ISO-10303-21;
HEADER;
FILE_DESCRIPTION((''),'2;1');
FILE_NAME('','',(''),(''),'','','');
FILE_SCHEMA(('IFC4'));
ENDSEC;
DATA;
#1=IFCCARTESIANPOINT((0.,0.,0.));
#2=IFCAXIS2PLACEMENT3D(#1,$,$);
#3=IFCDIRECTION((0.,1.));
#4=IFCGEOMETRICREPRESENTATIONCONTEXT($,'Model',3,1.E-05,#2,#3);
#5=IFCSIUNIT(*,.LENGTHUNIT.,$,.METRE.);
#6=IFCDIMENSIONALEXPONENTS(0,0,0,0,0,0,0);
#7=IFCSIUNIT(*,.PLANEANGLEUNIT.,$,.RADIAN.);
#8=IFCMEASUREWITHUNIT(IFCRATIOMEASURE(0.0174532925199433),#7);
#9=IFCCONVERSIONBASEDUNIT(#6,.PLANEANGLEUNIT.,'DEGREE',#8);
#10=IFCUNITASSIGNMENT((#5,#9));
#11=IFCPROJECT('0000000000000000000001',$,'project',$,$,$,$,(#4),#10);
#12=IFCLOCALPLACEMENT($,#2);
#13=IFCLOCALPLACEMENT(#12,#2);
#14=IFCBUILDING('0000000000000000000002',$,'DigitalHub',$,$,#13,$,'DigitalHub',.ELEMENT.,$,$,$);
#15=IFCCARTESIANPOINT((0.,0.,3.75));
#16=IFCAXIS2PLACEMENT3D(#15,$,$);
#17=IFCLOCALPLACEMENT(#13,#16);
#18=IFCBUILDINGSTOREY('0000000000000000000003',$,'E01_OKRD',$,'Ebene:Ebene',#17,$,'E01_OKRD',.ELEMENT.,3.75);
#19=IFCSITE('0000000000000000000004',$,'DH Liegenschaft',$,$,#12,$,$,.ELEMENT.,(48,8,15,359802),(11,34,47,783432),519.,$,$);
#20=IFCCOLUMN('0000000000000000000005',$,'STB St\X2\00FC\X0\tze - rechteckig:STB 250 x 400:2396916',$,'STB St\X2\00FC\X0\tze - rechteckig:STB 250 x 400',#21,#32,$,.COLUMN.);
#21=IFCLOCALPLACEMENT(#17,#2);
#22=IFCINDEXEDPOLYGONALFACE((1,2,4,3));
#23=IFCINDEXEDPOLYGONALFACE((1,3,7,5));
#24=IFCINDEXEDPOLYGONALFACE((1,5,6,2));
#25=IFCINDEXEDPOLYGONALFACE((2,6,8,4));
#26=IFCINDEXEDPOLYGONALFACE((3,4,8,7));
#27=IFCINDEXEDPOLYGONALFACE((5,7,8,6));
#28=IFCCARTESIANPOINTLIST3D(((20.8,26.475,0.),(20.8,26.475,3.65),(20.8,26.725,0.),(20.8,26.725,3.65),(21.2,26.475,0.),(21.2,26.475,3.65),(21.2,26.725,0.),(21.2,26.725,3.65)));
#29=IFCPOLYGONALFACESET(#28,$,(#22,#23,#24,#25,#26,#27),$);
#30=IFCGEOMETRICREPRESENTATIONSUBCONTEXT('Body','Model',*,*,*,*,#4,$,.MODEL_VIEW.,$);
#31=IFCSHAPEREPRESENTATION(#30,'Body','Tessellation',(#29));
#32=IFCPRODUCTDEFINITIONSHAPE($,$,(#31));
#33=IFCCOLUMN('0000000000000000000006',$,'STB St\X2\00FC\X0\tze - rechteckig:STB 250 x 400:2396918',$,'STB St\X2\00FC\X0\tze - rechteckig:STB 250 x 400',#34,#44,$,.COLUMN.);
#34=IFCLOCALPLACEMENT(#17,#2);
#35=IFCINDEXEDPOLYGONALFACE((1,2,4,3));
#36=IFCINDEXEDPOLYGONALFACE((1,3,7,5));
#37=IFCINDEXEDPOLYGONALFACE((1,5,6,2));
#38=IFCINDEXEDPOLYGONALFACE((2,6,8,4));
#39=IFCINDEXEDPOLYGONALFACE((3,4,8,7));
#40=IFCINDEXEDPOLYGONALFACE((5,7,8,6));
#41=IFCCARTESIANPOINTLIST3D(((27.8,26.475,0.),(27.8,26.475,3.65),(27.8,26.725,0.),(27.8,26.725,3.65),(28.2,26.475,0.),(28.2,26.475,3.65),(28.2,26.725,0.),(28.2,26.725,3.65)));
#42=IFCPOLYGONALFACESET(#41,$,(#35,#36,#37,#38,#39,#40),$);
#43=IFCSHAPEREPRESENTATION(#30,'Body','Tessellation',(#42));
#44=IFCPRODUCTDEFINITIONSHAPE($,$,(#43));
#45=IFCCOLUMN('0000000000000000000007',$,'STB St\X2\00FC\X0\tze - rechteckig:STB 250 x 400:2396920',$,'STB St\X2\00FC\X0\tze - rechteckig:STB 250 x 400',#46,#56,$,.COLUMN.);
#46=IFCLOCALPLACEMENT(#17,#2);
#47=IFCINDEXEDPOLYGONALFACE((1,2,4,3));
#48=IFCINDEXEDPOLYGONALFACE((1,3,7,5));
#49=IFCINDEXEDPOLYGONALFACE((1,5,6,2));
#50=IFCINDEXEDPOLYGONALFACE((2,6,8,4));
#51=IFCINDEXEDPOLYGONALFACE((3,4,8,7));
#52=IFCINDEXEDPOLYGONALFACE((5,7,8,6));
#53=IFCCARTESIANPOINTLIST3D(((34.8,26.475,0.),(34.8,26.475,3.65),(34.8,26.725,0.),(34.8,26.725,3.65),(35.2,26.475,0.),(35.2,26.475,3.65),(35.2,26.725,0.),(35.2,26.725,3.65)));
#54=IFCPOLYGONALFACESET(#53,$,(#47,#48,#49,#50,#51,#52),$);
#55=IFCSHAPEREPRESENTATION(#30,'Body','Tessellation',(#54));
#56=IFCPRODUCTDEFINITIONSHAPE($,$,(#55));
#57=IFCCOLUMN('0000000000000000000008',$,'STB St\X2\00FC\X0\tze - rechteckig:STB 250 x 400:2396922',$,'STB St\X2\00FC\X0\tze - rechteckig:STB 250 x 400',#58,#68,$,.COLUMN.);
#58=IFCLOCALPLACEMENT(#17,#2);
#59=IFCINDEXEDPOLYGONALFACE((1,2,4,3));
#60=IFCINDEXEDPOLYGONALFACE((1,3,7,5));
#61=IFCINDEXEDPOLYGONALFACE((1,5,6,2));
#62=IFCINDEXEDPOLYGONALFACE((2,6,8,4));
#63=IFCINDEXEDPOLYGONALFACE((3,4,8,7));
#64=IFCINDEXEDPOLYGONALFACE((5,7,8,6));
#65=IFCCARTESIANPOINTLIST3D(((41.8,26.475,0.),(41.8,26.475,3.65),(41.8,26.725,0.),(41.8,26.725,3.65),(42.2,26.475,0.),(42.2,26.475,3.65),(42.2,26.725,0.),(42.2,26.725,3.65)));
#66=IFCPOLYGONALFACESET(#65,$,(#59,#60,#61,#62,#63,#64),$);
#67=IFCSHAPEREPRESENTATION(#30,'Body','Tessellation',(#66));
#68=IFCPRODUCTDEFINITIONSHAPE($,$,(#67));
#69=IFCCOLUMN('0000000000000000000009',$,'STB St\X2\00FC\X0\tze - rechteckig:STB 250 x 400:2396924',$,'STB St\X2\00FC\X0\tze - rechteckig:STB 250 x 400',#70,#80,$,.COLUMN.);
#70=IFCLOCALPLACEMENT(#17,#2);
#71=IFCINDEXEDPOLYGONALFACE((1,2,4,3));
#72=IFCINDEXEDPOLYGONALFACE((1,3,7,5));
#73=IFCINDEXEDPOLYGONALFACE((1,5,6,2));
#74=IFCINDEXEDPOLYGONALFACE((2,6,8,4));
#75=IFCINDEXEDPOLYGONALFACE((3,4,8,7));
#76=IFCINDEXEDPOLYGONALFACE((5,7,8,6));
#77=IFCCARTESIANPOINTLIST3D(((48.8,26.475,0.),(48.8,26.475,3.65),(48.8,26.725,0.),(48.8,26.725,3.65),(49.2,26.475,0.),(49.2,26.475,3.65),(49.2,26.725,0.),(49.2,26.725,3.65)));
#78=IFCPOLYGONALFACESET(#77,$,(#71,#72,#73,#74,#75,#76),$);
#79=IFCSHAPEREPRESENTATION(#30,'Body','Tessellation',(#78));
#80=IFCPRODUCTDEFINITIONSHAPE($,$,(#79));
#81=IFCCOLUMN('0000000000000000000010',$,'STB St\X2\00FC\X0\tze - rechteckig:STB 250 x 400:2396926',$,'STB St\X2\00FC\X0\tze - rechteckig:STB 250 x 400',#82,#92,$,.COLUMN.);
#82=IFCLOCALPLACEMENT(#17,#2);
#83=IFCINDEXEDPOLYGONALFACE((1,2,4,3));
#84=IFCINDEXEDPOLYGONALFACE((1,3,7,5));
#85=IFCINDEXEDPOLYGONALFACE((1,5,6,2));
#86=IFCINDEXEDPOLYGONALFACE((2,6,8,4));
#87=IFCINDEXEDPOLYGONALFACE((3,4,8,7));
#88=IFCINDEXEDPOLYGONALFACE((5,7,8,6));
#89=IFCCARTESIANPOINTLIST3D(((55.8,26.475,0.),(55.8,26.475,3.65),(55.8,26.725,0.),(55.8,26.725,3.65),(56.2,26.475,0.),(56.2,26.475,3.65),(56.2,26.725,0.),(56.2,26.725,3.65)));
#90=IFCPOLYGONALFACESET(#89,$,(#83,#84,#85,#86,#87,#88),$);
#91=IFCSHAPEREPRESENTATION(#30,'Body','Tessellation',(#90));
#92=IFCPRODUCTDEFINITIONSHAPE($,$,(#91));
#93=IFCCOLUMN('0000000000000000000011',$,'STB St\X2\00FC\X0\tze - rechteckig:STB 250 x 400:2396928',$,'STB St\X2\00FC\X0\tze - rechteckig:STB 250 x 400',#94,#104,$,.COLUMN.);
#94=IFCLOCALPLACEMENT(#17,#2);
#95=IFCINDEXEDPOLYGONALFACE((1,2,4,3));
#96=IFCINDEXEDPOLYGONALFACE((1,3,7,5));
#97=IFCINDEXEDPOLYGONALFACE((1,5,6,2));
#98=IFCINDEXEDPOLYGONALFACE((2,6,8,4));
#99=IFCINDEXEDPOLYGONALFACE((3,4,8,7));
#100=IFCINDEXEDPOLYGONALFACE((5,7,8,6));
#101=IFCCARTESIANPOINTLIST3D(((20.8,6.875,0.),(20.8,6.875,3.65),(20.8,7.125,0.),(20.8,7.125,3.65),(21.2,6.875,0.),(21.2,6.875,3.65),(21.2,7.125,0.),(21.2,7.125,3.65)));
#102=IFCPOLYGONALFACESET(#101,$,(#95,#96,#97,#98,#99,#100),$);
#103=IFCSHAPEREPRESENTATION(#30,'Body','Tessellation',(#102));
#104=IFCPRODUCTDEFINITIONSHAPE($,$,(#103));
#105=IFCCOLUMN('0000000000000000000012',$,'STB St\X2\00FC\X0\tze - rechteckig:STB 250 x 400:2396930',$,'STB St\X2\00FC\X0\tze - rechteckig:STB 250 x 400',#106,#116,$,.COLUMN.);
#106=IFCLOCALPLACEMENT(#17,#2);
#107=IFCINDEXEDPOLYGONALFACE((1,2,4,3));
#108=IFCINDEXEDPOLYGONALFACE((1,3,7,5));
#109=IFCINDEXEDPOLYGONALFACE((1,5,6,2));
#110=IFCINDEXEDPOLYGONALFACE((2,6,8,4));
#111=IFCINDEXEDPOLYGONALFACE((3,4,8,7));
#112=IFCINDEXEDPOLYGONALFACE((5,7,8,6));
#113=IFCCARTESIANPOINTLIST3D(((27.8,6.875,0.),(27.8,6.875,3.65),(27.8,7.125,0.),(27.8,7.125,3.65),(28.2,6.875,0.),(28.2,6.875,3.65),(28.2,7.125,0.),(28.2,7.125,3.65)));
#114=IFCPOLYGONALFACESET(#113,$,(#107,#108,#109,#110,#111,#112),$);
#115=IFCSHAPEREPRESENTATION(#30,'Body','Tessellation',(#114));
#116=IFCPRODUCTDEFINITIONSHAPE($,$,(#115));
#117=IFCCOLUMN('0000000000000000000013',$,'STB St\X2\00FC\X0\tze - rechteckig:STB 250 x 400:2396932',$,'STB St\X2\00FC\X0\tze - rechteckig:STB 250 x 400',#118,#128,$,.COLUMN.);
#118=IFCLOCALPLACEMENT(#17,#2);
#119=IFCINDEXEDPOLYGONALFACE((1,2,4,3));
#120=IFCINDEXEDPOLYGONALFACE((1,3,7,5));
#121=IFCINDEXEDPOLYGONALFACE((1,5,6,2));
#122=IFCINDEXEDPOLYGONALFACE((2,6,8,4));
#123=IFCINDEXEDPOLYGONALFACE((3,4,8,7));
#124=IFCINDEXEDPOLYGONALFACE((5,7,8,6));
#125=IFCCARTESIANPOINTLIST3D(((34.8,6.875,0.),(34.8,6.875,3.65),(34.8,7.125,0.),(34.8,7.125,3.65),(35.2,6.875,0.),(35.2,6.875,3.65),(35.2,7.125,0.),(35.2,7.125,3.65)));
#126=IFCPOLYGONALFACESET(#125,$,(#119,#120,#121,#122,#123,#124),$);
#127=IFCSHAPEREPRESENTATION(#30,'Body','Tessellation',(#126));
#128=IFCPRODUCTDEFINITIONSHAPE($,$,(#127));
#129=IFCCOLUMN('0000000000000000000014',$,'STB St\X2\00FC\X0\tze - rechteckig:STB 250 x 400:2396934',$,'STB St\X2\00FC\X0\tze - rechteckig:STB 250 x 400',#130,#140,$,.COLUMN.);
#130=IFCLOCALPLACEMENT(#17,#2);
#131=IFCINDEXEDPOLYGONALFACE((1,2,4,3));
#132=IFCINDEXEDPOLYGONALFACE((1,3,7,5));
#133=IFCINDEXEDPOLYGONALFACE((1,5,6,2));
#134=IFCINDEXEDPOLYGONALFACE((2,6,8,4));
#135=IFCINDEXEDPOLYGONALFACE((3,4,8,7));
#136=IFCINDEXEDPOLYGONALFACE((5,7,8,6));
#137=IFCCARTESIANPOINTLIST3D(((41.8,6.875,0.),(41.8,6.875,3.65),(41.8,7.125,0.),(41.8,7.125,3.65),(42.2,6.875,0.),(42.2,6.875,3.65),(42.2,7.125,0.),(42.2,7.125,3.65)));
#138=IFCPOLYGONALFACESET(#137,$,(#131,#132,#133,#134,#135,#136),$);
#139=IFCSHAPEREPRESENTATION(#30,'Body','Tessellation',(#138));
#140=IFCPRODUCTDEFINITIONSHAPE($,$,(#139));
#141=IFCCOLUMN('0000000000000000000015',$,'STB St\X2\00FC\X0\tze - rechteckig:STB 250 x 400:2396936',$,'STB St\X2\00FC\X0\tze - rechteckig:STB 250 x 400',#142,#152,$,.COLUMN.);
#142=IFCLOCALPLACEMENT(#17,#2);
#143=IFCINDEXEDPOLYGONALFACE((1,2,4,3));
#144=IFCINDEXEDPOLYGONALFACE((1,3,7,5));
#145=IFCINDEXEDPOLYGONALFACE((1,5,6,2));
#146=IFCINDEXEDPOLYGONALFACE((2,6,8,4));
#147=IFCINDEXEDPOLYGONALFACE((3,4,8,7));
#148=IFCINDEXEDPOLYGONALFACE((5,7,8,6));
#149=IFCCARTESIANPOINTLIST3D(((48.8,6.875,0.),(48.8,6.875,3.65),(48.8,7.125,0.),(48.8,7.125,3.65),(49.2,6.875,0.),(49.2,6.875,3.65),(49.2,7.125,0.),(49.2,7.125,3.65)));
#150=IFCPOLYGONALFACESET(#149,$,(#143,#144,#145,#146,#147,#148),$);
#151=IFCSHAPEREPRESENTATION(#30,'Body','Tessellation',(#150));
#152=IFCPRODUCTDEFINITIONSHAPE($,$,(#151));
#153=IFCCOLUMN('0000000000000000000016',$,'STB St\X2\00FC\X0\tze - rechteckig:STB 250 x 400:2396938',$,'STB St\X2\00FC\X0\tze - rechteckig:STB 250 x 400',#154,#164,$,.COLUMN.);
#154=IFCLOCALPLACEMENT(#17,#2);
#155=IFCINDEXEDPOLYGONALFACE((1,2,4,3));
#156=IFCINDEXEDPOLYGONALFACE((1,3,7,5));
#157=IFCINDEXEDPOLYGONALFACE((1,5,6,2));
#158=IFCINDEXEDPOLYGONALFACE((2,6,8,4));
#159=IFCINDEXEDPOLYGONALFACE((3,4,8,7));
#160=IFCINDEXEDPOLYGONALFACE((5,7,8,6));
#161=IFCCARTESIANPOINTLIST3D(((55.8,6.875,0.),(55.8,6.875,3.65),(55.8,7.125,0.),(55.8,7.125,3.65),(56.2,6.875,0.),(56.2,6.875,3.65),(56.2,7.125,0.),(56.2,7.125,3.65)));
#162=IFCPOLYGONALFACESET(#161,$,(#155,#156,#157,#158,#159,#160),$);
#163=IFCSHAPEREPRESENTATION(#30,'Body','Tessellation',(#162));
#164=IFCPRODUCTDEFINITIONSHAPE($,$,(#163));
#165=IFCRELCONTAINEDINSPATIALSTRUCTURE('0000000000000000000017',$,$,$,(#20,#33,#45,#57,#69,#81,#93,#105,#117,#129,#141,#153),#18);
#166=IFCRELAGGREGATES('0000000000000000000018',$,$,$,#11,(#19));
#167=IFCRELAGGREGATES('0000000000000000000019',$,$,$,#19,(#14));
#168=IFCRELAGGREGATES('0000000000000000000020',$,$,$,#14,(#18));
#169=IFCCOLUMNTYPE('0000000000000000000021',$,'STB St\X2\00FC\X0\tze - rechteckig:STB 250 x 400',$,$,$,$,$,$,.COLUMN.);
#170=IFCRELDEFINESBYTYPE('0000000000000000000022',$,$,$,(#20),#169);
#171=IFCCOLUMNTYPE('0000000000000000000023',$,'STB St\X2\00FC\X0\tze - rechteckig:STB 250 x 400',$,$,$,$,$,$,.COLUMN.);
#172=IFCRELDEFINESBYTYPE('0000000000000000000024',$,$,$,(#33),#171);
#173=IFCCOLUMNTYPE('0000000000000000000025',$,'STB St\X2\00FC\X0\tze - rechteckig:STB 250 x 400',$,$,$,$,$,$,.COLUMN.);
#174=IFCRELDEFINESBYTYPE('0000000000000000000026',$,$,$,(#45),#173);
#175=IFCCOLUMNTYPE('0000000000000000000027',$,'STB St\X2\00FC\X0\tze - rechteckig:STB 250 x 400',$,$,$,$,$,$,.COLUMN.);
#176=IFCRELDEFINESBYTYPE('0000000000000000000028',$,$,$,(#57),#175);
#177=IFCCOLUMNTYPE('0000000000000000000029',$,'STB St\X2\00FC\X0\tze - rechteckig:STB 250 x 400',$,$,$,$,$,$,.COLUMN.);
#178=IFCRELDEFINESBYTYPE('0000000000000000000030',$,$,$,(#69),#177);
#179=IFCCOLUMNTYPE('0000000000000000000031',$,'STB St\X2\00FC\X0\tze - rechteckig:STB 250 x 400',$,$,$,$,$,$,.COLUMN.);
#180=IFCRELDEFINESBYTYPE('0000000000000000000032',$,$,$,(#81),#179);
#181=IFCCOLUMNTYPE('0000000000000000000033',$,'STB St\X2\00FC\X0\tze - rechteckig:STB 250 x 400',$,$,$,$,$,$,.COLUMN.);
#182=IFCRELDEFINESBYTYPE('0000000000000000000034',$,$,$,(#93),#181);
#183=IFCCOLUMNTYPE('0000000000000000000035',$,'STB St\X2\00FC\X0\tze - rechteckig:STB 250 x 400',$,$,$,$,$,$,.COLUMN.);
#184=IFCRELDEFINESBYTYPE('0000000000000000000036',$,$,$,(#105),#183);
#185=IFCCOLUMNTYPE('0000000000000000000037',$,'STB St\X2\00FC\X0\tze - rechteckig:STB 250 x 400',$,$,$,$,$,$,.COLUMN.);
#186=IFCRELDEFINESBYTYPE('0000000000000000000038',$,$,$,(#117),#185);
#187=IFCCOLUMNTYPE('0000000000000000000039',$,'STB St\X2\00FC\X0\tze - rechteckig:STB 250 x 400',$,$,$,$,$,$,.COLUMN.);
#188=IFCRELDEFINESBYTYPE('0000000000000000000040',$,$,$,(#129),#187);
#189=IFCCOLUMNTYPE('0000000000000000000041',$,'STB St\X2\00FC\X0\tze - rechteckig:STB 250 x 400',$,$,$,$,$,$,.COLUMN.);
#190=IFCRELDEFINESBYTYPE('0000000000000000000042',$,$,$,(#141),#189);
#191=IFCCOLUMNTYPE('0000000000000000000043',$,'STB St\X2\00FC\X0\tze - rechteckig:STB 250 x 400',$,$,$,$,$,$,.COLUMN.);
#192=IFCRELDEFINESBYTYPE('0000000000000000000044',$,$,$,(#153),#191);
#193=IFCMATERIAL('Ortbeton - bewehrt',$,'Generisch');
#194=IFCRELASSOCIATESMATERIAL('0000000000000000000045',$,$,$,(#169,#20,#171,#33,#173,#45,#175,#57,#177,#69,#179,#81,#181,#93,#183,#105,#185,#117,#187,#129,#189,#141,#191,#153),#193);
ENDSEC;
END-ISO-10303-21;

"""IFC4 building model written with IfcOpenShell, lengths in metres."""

from ifc_helpers import new_model, entity, si_unit, converted_unit, direction, frame, origin, place, context, subcontext, project, spatial, indexed_curve, outline, extrude, source, transform, mapped, material, type_object, type_shapes, element, save


model = new_model("IFC4")

# Units and contexts
model_context = context("Model", 3, precision=1e-05, world=origin(), true_north=direction((0.0, 1.0)))
body_context = subcontext(model_context, "Body", "Model", "MODEL_VIEW")
ifc_project = project(units=[si_unit("LENGTHUNIT", "METRE"), converted_unit("PLANEANGLEUNIT", "DEGREE", entity("IfcRatioMeasure", 0.0174532925199433), si_unit("PLANEANGLEUNIT", "RADIAN"), dimensions=[0, 0, 0, 0, 0, 0, 0])], contexts=[model_context])

# Site, building, storey
site_placement = place(None, frame((0.0, 0.0, 0.0)))
site = spatial("IfcSite", under=ifc_project, at=site_placement, Name="DH Liegenschaft", CompositionType="ELEMENT", RefLatitude=(48, 8, 15, 359802), RefLongitude=(11, 34, 47, 783432), RefElevation=519.0)
building_placement = place(site_placement, origin())
building = spatial("IfcBuilding", under=site, at=building_placement, Name="DigitalHub", LongName="DigitalHub", CompositionType="ELEMENT")
storey_placement = place(building_placement, frame((0.0, 0.0, 3.75)))
storey = spatial("IfcBuildingStorey", under=building, at=storey_placement, Name="E01_OKRD", ObjectType="Ebene:Ebene", LongName="E01_OKRD", CompositionType="ELEMENT", Elevation=3.75)

# Columns
ifc_material = material(Name="Ortbeton - bewehrt", Category="Generisch")
column_type_1 = type_object("IfcColumnType", Name="STB Stütze - rechteckig:STB 250 x 400", PredefinedType="COLUMN", material=ifc_material)
shared_shape_1 = source(origin(), body_context, "Body", "SweptSolid", [
    extrude(outline(indexed_curve([(-0.125, -0.2), (0.125, -0.2), (0.125, 0.2), (-0.125, 0.2), (-0.125, -0.2)], self_intersect=False)), frame((21.0, 26.6, 3.75), z_axis=(0.0, 0.0, 1.0), x_axis=(0.0, -1.0, 0.0)), (0.0, 0.0, 1.0), 3.65),
])
type_shapes(column_type_1, [shared_shape_1])
column_1_placement = place(storey_placement, frame((0.0, 0.0, -3.75)))
element("IfcColumn", 1, at=column_1_placement, inside=storey, type_object=column_type_1, material=ifc_material, Name="STB Stütze - rechteckig:STB 250 x 400:2396916", ObjectType="STB Stütze - rechteckig:STB 250 x 400", PredefinedType="COLUMN", context=body_context, shape_type="MappedRepresentation", body=[
    mapped(shared_shape_1, transform((0.0, 0.0, 0.0), scale=1.0)),
])
column_type_2 = type_object("IfcColumnType", Name="STB Stütze - rechteckig:STB 250 x 400", PredefinedType="COLUMN", material=ifc_material)
shared_shape_2 = source(origin(), body_context, "Body", "SweptSolid", [
    extrude(outline(indexed_curve([(-0.125, -0.2), (0.125, -0.2), (0.125, 0.2), (-0.125, 0.2), (-0.125, -0.2)], self_intersect=False)), frame((28.0, 26.6, 3.75), z_axis=(0.0, 0.0, 1.0), x_axis=(0.0, -1.0, 0.0)), (0.0, 0.0, 1.0), 3.65),
])
type_shapes(column_type_2, [shared_shape_2])
column_2_placement = place(storey_placement, frame((0.0, 0.0, -3.75)))
element("IfcColumn", 2, at=column_2_placement, inside=storey, type_object=column_type_2, material=ifc_material, Name="STB Stütze - rechteckig:STB 250 x 400:2396918", ObjectType="STB Stütze - rechteckig:STB 250 x 400", PredefinedType="COLUMN", context=body_context, shape_type="MappedRepresentation", body=[
    mapped(shared_shape_2, transform((0.0, 0.0, 0.0), scale=1.0)),
])
column_type_3 = type_object("IfcColumnType", Name="STB Stütze - rechteckig:STB 250 x 400", PredefinedType="COLUMN", material=ifc_material)
shared_shape_3 = source(origin(), body_context, "Body", "SweptSolid", [
    extrude(outline(indexed_curve([(-0.125, -0.2), (0.125, -0.2), (0.125, 0.2), (-0.125, 0.2), (-0.125, -0.2)], self_intersect=False)), frame((35.0, 26.6, 3.75), z_axis=(0.0, 0.0, 1.0), x_axis=(0.0, -1.0, 0.0)), (0.0, 0.0, 1.0), 3.65),
])
type_shapes(column_type_3, [shared_shape_3])
column_3_placement = place(storey_placement, frame((0.0, 0.0, -3.75)))
element("IfcColumn", 3, at=column_3_placement, inside=storey, type_object=column_type_3, material=ifc_material, Name="STB Stütze - rechteckig:STB 250 x 400:2396920", ObjectType="STB Stütze - rechteckig:STB 250 x 400", PredefinedType="COLUMN", context=body_context, shape_type="MappedRepresentation", body=[
    mapped(shared_shape_3, transform((0.0, 0.0, 0.0), scale=1.0)),
])
column_type_4 = type_object("IfcColumnType", Name="STB Stütze - rechteckig:STB 250 x 400", PredefinedType="COLUMN", material=ifc_material)
shared_shape_4 = source(origin(), body_context, "Body", "SweptSolid", [
    extrude(outline(indexed_curve([(-0.125, -0.2), (0.125, -0.2), (0.125, 0.2), (-0.125, 0.2), (-0.125, -0.2)], self_intersect=False)), frame((42.0, 26.6, 3.75), z_axis=(0.0, 0.0, 1.0), x_axis=(0.0, -1.0, 0.0)), (0.0, 0.0, 1.0), 3.65),
])
type_shapes(column_type_4, [shared_shape_4])
column_4_placement = place(storey_placement, frame((0.0, 0.0, -3.75)))
element("IfcColumn", 4, at=column_4_placement, inside=storey, type_object=column_type_4, material=ifc_material, Name="STB Stütze - rechteckig:STB 250 x 400:2396922", ObjectType="STB Stütze - rechteckig:STB 250 x 400", PredefinedType="COLUMN", context=body_context, shape_type="MappedRepresentation", body=[
    mapped(shared_shape_4, transform((0.0, 0.0, 0.0), scale=1.0)),
])
column_type_5 = type_object("IfcColumnType", Name="STB Stütze - rechteckig:STB 250 x 400", PredefinedType="COLUMN", material=ifc_material)
shared_shape_5 = source(origin(), body_context, "Body", "SweptSolid", [
    extrude(outline(indexed_curve([(-0.125, -0.2), (0.125, -0.2), (0.125, 0.2), (-0.125, 0.2), (-0.125, -0.2)], self_intersect=False)), frame((49.0, 26.6, 3.75), z_axis=(0.0, 0.0, 1.0), x_axis=(0.0, -1.0, 0.0)), (0.0, 0.0, 1.0), 3.65),
])
type_shapes(column_type_5, [shared_shape_5])
column_5_placement = place(storey_placement, frame((0.0, 0.0, -3.75)))
element("IfcColumn", 5, at=column_5_placement, inside=storey, type_object=column_type_5, material=ifc_material, Name="STB Stütze - rechteckig:STB 250 x 400:2396924", ObjectType="STB Stütze - rechteckig:STB 250 x 400", PredefinedType="COLUMN", context=body_context, shape_type="MappedRepresentation", body=[
    mapped(shared_shape_5, transform((0.0, 0.0, 0.0), scale=1.0)),
])
column_type_6 = type_object("IfcColumnType", Name="STB Stütze - rechteckig:STB 250 x 400", PredefinedType="COLUMN", material=ifc_material)
shared_shape_6 = source(origin(), body_context, "Body", "SweptSolid", [
    extrude(outline(indexed_curve([(-0.125, -0.2), (0.125, -0.2), (0.125, 0.2), (-0.125, 0.2), (-0.125, -0.2)], self_intersect=False)), frame((56.0, 26.6, 3.75), z_axis=(0.0, 0.0, 1.0), x_axis=(0.0, -1.0, 0.0)), (0.0, 0.0, 1.0), 3.65),
])
type_shapes(column_type_6, [shared_shape_6])
column_6_placement = place(storey_placement, frame((0.0, 0.0, -3.75)))
element("IfcColumn", 6, at=column_6_placement, inside=storey, type_object=column_type_6, material=ifc_material, Name="STB Stütze - rechteckig:STB 250 x 400:2396926", ObjectType="STB Stütze - rechteckig:STB 250 x 400", PredefinedType="COLUMN", context=body_context, shape_type="MappedRepresentation", body=[
    mapped(shared_shape_6, transform((0.0, 0.0, 0.0), scale=1.0)),
])
column_type_7 = type_object("IfcColumnType", Name="STB Stütze - rechteckig:STB 250 x 400", PredefinedType="COLUMN", material=ifc_material)
shared_shape_7 = source(origin(), body_context, "Body", "SweptSolid", [
    extrude(outline(indexed_curve([(-0.125, -0.2), (0.125, -0.2), (0.125, 0.2), (-0.125, 0.2), (-0.125, -0.2)], self_intersect=False)), frame((21.0, 7.0, 3.75), z_axis=(0.0, 0.0, 1.0), x_axis=(0.0, -1.0, 0.0)), (0.0, 0.0, 1.0), 3.65),
])
type_shapes(column_type_7, [shared_shape_7])
column_7_placement = place(storey_placement, frame((0.0, 0.0, -3.75)))
element("IfcColumn", 7, at=column_7_placement, inside=storey, type_object=column_type_7, material=ifc_material, Name="STB Stütze - rechteckig:STB 250 x 400:2396928", ObjectType="STB Stütze - rechteckig:STB 250 x 400", PredefinedType="COLUMN", context=body_context, shape_type="MappedRepresentation", body=[
    mapped(shared_shape_7, transform((0.0, 0.0, 0.0), scale=1.0)),
])
column_type_8 = type_object("IfcColumnType", Name="STB Stütze - rechteckig:STB 250 x 400", PredefinedType="COLUMN", material=ifc_material)
shared_shape_8 = source(origin(), body_context, "Body", "SweptSolid", [
    extrude(outline(indexed_curve([(-0.125, -0.2), (0.125, -0.2), (0.125, 0.2), (-0.125, 0.2), (-0.125, -0.2)], self_intersect=False)), frame((28.0, 7.0, 3.75), z_axis=(0.0, 0.0, 1.0), x_axis=(0.0, -1.0, 0.0)), (0.0, 0.0, 1.0), 3.65),
])
type_shapes(column_type_8, [shared_shape_8])
column_8_placement = place(storey_placement, frame((0.0, 0.0, -3.75)))
element("IfcColumn", 8, at=column_8_placement, inside=storey, type_object=column_type_8, material=ifc_material, Name="STB Stütze - rechteckig:STB 250 x 400:2396930", ObjectType="STB Stütze - rechteckig:STB 250 x 400", PredefinedType="COLUMN", context=body_context, shape_type="MappedRepresentation", body=[
    mapped(shared_shape_8, transform((0.0, 0.0, 0.0), scale=1.0)),
])
column_type_9 = type_object("IfcColumnType", Name="STB Stütze - rechteckig:STB 250 x 400", PredefinedType="COLUMN", material=ifc_material)
shared_shape_9 = source(origin(), body_context, "Body", "SweptSolid", [
    extrude(outline(indexed_curve([(-0.125, -0.2), (0.125, -0.2), (0.125, 0.2), (-0.125, 0.2), (-0.125, -0.2)], self_intersect=False)), frame((35.0, 7.0, 3.75), z_axis=(0.0, 0.0, 1.0), x_axis=(0.0, -1.0, 0.0)), (0.0, 0.0, 1.0), 3.65),
])
type_shapes(column_type_9, [shared_shape_9])
column_9_placement = place(storey_placement, frame((0.0, 0.0, -3.75)))
element("IfcColumn", 9, at=column_9_placement, inside=storey, type_object=column_type_9, material=ifc_material, Name="STB Stütze - rechteckig:STB 250 x 400:2396932", ObjectType="STB Stütze - rechteckig:STB 250 x 400", PredefinedType="COLUMN", context=body_context, shape_type="MappedRepresentation", body=[
    mapped(shared_shape_9, transform((0.0, 0.0, 0.0), scale=1.0)),
])
column_type_10 = type_object("IfcColumnType", Name="STB Stütze - rechteckig:STB 250 x 400", PredefinedType="COLUMN", material=ifc_material)
shared_shape_10 = source(origin(), body_context, "Body", "SweptSolid", [
    extrude(outline(indexed_curve([(-0.125, -0.2), (0.125, -0.2), (0.125, 0.2), (-0.125, 0.2), (-0.125, -0.2)], self_intersect=False)), frame((42.0, 7.0, 3.75), z_axis=(0.0, 0.0, 1.0), x_axis=(0.0, -1.0, 0.0)), (0.0, 0.0, 1.0), 3.65),
])
type_shapes(column_type_10, [shared_shape_10])
column_10_placement = place(storey_placement, frame((0.0, 0.0, -3.75)))
element("IfcColumn", 10, at=column_10_placement, inside=storey, type_object=column_type_10, material=ifc_material, Name="STB Stütze - rechteckig:STB 250 x 400:2396934", ObjectType="STB Stütze - rechteckig:STB 250 x 400", PredefinedType="COLUMN", context=body_context, shape_type="MappedRepresentation", body=[
    mapped(shared_shape_10, transform((0.0, 0.0, 0.0), scale=1.0)),
])
column_type_11 = type_object("IfcColumnType", Name="STB Stütze - rechteckig:STB 250 x 400", PredefinedType="COLUMN", material=ifc_material)
shared_shape_11 = source(origin(), body_context, "Body", "SweptSolid", [
    extrude(outline(indexed_curve([(-0.125, -0.2), (0.125, -0.2), (0.125, 0.2), (-0.125, 0.2), (-0.125, -0.2)], self_intersect=False)), frame((49.0, 7.0, 3.75), z_axis=(0.0, 0.0, 1.0), x_axis=(0.0, -1.0, 0.0)), (0.0, 0.0, 1.0), 3.65),
])
type_shapes(column_type_11, [shared_shape_11])
column_11_placement = place(storey_placement, frame((0.0, 0.0, -3.75)))
element("IfcColumn", 11, at=column_11_placement, inside=storey, type_object=column_type_11, material=ifc_material, Name="STB Stütze - rechteckig:STB 250 x 400:2396936", ObjectType="STB Stütze - rechteckig:STB 250 x 400", PredefinedType="COLUMN", context=body_context, shape_type="MappedRepresentation", body=[
    mapped(shared_shape_11, transform((0.0, 0.0, 0.0), scale=1.0)),
])
column_type_12 = type_object("IfcColumnType", Name="STB Stütze - rechteckig:STB 250 x 400", PredefinedType="COLUMN", material=ifc_material)
shared_shape_12 = source(origin(), body_context, "Body", "SweptSolid", [
    extrude(outline(indexed_curve([(-0.125, -0.2), (0.125, -0.2), (0.125, 0.2), (-0.125, 0.2), (-0.125, -0.2)], self_intersect=False)), frame((56.0, 7.0, 3.75), z_axis=(0.0, 0.0, 1.0), x_axis=(0.0, -1.0, 0.0)), (0.0, 0.0, 1.0), 3.65),
])
type_shapes(column_type_12, [shared_shape_12])
column_12_placement = place(storey_placement, frame((0.0, 0.0, -3.75)))
element("IfcColumn", 12, at=column_12_placement, inside=storey, type_object=column_type_12, material=ifc_material, Name="STB Stütze - rechteckig:STB 250 x 400:2396938", ObjectType="STB Stütze - rechteckig:STB 250 x 400", PredefinedType="COLUMN", context=body_context, shape_type="MappedRepresentation", body=[
    mapped(shared_shape_12, transform((0.0, 0.0, 0.0), scale=1.0)),
])

save(model, "model.ifc")
